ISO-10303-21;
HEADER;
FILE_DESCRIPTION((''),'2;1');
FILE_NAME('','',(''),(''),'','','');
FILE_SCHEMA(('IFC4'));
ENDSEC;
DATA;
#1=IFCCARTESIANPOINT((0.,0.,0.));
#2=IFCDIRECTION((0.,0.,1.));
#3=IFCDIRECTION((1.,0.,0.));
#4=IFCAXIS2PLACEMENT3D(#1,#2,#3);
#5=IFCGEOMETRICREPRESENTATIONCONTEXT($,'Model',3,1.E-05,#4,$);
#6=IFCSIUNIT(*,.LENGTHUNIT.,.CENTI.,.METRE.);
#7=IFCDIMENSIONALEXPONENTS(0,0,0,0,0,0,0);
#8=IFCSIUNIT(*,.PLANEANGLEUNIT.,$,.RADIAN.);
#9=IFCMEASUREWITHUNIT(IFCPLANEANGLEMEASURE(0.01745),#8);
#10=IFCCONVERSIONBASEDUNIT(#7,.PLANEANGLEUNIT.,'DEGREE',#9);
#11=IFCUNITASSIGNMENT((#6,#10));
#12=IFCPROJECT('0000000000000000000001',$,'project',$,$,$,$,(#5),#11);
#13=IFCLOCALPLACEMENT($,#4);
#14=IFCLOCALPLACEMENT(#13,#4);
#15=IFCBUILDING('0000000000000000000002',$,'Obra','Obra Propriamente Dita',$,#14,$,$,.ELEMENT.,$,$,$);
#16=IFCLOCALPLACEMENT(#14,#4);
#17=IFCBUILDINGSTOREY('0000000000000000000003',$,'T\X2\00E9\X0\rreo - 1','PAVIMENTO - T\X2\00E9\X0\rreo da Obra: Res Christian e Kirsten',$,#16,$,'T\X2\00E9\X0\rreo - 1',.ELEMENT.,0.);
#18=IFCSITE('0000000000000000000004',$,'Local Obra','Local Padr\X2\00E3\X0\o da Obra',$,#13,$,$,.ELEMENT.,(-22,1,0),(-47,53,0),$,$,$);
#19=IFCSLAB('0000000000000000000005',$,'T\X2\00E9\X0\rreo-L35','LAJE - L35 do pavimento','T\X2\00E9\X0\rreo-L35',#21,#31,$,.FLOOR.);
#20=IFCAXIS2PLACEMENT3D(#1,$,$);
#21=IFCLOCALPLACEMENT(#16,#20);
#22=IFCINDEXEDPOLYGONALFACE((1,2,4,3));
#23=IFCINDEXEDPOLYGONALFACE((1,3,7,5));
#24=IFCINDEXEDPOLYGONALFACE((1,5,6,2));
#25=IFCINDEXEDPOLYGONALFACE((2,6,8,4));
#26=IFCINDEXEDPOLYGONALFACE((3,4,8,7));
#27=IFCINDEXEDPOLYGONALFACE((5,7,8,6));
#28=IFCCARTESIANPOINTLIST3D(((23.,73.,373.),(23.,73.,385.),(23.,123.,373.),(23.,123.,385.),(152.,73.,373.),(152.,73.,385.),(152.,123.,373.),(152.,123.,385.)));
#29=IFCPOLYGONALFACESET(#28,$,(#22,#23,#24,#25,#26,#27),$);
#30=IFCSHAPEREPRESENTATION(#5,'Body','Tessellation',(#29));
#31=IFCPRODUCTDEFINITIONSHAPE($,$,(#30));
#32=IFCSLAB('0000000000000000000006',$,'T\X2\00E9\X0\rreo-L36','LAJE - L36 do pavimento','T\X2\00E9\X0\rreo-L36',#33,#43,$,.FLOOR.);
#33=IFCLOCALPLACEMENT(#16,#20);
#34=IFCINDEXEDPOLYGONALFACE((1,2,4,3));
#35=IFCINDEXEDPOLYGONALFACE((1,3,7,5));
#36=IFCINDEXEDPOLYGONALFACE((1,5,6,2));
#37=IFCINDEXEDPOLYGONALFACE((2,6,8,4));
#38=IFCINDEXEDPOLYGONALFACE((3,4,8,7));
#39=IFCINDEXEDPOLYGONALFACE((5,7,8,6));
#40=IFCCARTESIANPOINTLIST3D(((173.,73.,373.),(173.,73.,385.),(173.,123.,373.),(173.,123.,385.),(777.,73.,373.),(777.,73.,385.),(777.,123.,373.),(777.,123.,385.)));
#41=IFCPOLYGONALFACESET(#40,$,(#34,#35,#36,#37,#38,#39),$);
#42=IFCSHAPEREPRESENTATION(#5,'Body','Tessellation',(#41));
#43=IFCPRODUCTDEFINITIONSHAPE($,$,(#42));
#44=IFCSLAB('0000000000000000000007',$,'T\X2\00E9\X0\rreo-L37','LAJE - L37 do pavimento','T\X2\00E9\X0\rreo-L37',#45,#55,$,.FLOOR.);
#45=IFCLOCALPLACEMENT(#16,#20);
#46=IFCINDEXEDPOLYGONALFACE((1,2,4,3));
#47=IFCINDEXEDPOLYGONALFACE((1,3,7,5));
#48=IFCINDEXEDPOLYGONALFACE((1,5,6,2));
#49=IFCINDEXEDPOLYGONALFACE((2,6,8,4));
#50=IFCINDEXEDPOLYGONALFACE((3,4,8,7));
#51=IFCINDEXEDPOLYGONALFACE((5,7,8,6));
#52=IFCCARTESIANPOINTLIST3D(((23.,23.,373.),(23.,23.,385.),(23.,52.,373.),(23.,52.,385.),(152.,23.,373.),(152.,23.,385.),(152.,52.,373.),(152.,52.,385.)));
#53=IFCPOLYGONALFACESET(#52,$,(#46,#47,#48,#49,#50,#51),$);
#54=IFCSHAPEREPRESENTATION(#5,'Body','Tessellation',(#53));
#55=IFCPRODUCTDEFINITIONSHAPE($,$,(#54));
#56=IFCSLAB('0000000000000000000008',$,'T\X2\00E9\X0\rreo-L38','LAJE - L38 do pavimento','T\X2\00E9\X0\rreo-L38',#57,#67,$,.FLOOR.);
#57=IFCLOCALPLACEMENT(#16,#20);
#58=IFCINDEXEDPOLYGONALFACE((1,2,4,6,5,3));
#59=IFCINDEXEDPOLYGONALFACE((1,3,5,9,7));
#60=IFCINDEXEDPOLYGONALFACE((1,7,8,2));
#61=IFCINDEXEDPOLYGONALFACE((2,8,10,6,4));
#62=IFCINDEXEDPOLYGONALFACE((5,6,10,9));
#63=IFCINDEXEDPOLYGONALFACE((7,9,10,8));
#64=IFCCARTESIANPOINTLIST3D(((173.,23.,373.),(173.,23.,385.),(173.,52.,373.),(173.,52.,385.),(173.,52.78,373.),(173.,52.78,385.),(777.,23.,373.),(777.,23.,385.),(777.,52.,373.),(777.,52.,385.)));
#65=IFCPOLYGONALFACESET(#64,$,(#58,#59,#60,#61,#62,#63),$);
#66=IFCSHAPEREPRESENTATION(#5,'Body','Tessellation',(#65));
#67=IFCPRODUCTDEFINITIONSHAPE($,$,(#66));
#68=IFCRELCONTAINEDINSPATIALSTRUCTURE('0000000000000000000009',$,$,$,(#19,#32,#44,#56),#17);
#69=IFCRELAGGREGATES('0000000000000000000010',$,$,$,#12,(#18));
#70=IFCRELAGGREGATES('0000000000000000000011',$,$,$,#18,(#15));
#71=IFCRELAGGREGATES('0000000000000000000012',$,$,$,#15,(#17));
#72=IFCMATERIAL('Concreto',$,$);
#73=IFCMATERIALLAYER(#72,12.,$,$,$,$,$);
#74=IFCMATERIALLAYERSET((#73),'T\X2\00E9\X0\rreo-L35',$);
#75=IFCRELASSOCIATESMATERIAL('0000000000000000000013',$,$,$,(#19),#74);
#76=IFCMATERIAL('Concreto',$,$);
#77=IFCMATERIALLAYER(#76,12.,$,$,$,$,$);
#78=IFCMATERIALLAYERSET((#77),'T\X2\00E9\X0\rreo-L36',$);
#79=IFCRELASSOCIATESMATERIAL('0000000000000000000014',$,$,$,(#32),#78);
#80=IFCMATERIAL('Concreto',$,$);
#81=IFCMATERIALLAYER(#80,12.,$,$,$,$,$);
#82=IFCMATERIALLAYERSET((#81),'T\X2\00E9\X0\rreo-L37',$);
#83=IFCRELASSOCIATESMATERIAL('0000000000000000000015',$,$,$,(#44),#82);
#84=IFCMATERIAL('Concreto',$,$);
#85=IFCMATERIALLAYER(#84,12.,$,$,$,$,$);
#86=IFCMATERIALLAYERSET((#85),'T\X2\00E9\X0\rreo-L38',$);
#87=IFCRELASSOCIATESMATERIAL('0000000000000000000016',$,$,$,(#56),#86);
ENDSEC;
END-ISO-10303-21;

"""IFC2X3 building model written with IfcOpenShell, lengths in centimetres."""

from ifc_helpers import new_model, entity, si_unit, converted_unit, frame, origin_with_axes, place, context, project, spatial, polyline, outline, extrude, material, layer, layer_set, layer_usage, element, save


model = new_model("IFC2X3")

# Units and contexts
model_context = context("Model", 3, precision=1e-05, world=origin_with_axes())
ifc_project = project(units=[si_unit("LENGTHUNIT", "METRE", prefix="CENTI"), converted_unit("PLANEANGLEUNIT", "DEGREE", entity("IfcPlaneAngleMeasure", 0.01745), si_unit("PLANEANGLEUNIT", "RADIAN"), dimensions=[0, 0, 0, 0, 0, 0, 0])], contexts=[model_context])

# Site, building, storey
site_placement = place(None, origin_with_axes())
site = spatial("IfcSite", under=ifc_project, at=site_placement, Name="Local Obra", Description="Local Padrão da Obra", CompositionType="ELEMENT", RefLatitude=(-22, 1, 0), RefLongitude=(-47, 53, 0))
building_placement = place(site_placement, origin_with_axes())
building = spatial("IfcBuilding", under=site, at=building_placement, Name="Obra", Description="Obra Propriamente Dita", CompositionType="ELEMENT")
storey_placement = place(building_placement, origin_with_axes())
storey = spatial("IfcBuildingStorey", under=building, at=storey_placement, Name="Térreo - 1", Description="PAVIMENTO - Térreo da Obra: Res Christian e Kirsten", LongName="Térreo - 1", CompositionType="ELEMENT", Elevation=0.0)

# Slabs
ifc_material_1 = material(Name="Concreto")
ifc_layer_1 = layer(ifc_material_1, 12.0)
ifc_layer_set_1 = layer_set([ifc_layer_1], Name="Térreo-L35")
ifc_layer_usage_1 = layer_usage(ifc_layer_set_1, "AXIS3", "POSITIVE", 0.0)
slab_1_placement = place(storey_placement, frame((152.0, 73.0, 373.0), z_axis=(0.0, 0.0, 1.0), x_axis=(1.0, 0.0, 0.0)))
element("IfcSlab", 1, at=slab_1_placement, inside=storey, material=ifc_layer_usage_1, Name="Térreo-L35", Description="LAJE - L35 do pavimento", ObjectType="Térreo-L35", PredefinedType="FLOOR", context=model_context, shape_type="SweptSolid", body=[
    extrude(outline(polyline([(0.0, 50.0), (-129.0, 50.0), (-129.0, 0.0), (0.0, 0.0), (0.0, 50.0)])), origin_with_axes(), (0.0, 0.0, 1.0), 12.0),
])
ifc_material_2 = material(Name="Concreto")
ifc_layer_2 = layer(ifc_material_2, 12.0)
ifc_layer_set_2 = layer_set([ifc_layer_2], Name="Térreo-L36")
ifc_layer_usage_2 = layer_usage(ifc_layer_set_2, "AXIS3", "POSITIVE", 0.0)
slab_2_placement = place(storey_placement, frame((777.0, 73.0, 373.0), z_axis=(0.0, 0.0, 1.0), x_axis=(1.0, 0.0, 0.0)))
element("IfcSlab", 2, at=slab_2_placement, inside=storey, material=ifc_layer_usage_2, Name="Térreo-L36", Description="LAJE - L36 do pavimento", ObjectType="Térreo-L36", PredefinedType="FLOOR", context=model_context, shape_type="SweptSolid", body=[
    extrude(outline(polyline([(0.0, 50.0), (-604.0, 50.0), (-604.0, 0.0), (0.0, 0.0), (0.0, 50.0)])), origin_with_axes(), (0.0, 0.0, 1.0), 12.0),
])
ifc_material_3 = material(Name="Concreto")
ifc_layer_3 = layer(ifc_material_3, 12.0)
ifc_layer_set_3 = layer_set([ifc_layer_3], Name="Térreo-L37")
ifc_layer_usage_3 = layer_usage(ifc_layer_set_3, "AXIS3", "POSITIVE", 0.0)
slab_3_placement = place(storey_placement, frame((152.0, 23.0, 373.0), z_axis=(0.0, 0.0, 1.0), x_axis=(1.0, 0.0, 0.0)))
element("IfcSlab", 3, at=slab_3_placement, inside=storey, material=ifc_layer_usage_3, Name="Térreo-L37", Description="LAJE - L37 do pavimento", ObjectType="Térreo-L37", PredefinedType="FLOOR", context=model_context, shape_type="SweptSolid", body=[
    extrude(outline(polyline([(0.0, 29.0), (-129.0, 29.0), (-129.0, 0.0), (0.0, 0.0), (0.0, 29.0)])), origin_with_axes(), (0.0, 0.0, 1.0), 12.0),
])
ifc_material_4 = material(Name="Concreto")
ifc_layer_4 = layer(ifc_material_4, 12.0)
ifc_layer_set_4 = layer_set([ifc_layer_4], Name="Térreo-L38")
ifc_layer_usage_4 = layer_usage(ifc_layer_set_4, "AXIS3", "POSITIVE", 0.0)
slab_4_placement = place(storey_placement, frame((777.0, 52.0, 373.0), z_axis=(0.0, 0.0, 1.0), x_axis=(1.0, 0.0, 0.0)))
element("IfcSlab", 4, at=slab_4_placement, inside=storey, material=ifc_layer_usage_4, Name="Térreo-L38", Description="LAJE - L38 do pavimento", ObjectType="Térreo-L38", PredefinedType="FLOOR", context=model_context, shape_type="SweptSolid", body=[
    extrude(outline(polyline([(-604.0, 0.78), (-604.0, 0.0), (-604.0, -29.0), (0.0, -29.0), (0.0, 0.0), (-604.0, 0.78)])), origin_with_axes(), (0.0, 0.0, 1.0), 12.0),
])

save(model, "model.ifc")
